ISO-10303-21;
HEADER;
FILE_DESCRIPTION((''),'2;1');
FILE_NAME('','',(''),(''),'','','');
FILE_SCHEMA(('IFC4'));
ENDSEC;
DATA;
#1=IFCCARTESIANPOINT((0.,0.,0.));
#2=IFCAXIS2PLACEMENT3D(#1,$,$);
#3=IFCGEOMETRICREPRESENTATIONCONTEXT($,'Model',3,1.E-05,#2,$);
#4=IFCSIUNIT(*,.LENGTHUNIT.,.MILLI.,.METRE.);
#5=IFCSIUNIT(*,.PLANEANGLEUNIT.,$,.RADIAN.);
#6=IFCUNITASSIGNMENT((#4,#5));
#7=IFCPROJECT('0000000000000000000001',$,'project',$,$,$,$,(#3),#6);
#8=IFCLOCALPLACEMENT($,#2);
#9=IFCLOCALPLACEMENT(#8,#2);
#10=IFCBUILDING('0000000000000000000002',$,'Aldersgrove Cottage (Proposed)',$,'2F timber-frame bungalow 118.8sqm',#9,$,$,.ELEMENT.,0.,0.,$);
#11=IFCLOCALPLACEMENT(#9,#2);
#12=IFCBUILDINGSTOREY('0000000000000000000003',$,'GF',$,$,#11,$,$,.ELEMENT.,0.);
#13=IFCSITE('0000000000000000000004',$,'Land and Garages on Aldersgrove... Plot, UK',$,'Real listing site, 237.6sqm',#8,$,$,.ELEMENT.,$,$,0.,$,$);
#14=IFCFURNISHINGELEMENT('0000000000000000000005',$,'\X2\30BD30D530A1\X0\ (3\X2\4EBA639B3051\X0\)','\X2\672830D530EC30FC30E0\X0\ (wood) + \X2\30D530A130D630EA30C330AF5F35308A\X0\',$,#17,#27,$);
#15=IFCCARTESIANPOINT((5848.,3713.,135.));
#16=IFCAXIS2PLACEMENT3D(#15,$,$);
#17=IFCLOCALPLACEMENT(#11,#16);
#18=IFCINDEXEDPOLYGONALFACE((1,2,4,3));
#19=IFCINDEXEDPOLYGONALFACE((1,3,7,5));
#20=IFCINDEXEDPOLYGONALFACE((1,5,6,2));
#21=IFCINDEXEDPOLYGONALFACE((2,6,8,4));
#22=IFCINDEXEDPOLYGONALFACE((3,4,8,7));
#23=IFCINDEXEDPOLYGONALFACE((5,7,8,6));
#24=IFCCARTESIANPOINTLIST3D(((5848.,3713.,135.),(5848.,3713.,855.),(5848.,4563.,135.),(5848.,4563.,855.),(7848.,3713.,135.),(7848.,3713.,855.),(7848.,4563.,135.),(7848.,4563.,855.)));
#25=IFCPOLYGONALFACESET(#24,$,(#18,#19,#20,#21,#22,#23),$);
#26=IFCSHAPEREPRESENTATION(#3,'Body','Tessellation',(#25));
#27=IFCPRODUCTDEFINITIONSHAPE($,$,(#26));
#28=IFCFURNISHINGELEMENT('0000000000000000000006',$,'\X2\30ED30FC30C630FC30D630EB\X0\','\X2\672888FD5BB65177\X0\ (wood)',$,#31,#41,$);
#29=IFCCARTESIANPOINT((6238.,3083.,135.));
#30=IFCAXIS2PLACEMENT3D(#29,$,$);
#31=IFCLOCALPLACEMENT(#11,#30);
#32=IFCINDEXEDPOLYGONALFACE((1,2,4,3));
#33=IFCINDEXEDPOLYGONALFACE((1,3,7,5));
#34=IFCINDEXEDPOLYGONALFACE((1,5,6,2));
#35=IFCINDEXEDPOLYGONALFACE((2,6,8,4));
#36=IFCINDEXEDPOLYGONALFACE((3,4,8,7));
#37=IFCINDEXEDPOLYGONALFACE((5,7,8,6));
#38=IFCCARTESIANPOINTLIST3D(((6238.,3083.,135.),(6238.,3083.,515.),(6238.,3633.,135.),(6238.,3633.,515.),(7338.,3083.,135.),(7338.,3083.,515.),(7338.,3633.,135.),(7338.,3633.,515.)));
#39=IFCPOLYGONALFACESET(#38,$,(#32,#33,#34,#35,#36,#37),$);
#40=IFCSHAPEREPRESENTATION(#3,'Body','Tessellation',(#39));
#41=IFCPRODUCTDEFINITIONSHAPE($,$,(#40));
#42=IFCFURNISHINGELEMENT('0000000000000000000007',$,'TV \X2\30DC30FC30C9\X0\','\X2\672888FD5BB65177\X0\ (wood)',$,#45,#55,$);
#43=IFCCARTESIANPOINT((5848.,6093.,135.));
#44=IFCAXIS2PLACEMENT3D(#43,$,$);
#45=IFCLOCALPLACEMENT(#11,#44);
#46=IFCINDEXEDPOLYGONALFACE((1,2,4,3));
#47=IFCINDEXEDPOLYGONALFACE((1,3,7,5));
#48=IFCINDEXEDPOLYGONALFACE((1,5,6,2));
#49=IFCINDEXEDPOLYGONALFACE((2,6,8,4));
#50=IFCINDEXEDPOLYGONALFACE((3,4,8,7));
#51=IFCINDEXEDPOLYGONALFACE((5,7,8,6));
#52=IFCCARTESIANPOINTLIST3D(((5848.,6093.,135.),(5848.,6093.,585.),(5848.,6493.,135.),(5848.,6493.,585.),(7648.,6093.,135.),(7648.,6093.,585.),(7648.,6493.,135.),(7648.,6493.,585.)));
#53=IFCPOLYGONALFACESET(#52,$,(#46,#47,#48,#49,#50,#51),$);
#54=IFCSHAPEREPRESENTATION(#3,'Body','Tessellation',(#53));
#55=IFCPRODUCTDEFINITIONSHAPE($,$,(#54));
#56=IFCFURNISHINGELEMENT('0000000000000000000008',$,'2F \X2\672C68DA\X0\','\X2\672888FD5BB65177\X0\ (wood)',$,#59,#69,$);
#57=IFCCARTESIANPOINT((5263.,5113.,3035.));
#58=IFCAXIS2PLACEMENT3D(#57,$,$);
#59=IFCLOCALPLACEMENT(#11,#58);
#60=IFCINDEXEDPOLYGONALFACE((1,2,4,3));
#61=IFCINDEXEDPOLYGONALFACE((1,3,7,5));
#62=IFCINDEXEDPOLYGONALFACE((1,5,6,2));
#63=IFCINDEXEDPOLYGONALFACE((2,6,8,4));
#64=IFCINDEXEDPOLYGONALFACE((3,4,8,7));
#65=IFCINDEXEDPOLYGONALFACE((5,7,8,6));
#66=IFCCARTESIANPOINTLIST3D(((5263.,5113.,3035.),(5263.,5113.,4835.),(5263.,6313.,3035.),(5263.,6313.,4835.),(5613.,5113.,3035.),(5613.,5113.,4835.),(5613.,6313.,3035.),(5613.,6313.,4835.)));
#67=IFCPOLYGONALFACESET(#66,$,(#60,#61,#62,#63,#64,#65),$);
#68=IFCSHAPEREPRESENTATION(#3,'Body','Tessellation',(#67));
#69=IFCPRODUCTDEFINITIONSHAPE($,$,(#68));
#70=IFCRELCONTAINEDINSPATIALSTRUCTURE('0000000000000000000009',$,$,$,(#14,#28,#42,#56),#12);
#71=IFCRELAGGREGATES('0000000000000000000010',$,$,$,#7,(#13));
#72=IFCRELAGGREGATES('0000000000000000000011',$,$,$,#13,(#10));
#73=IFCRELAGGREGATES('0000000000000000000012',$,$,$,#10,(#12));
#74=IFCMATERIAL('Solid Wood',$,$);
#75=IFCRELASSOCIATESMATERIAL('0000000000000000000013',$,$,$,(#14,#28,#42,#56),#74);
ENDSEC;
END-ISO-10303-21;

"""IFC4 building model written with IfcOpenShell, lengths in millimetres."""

from ifc_helpers import new_model, si_unit, frame, frame_2d, origin, place, context, project, spatial, rectangle, extrude, material, element, save


model = new_model("IFC4")

# Units and contexts
model_context = context("Model", 3, precision=1e-05, world=origin())
ifc_project = project(units=[si_unit("LENGTHUNIT", "METRE", prefix="MILLI"), si_unit("PLANEANGLEUNIT", "RADIAN")], contexts=[model_context])

# Site, building, storey
site_placement = place(None, origin())
site = spatial("IfcSite", under=ifc_project, at=site_placement, Name="Land and Garages on Aldersgrove... Plot, UK", ObjectType="Real listing site, 237.6sqm", CompositionType="ELEMENT", RefElevation=0.0)
building_placement = place(site_placement, origin())
building = spatial("IfcBuilding", under=site, at=building_placement, Name="Aldersgrove Cottage (Proposed)", ObjectType="2F timber-frame bungalow 118.8sqm", CompositionType="ELEMENT", ElevationOfRefHeight=0.0, ElevationOfTerrain=0.0)
storey_placement = place(building_placement, origin())
storey = spatial("IfcBuildingStorey", under=building, at=storey_placement, Name="GF", CompositionType="ELEMENT", Elevation=0.0)

# Shared definitions
ifc_material_1 = material(Name="Solid Wood")

# Furnishing elements
furnishing_1_placement = place(storey_placement, frame((5848.0, 3713.0, 135.0)))
element("IfcFurnishingElement", 1, at=furnishing_1_placement, inside=storey, material=ifc_material_1, Name="ソファ (3人掛け)", Description="木フレーム (wood) + ファブリック張り", context=model_context, shape_type="SweptSolid", body=[
    extrude(rectangle(XDim=2000.0, YDim=850.0, at=frame_2d((1000.0, 425.0))), frame((5848.0, 3713.0, 135.0)), (0.0, 0.0, 1.0), 720.0),
])
furnishing_2_placement = place(storey_placement, frame((6238.0, 3083.0, 135.0)))
element("IfcFurnishingElement", 2, at=furnishing_2_placement, inside=storey, material=ifc_material_1, Name="ローテーブル", Description="木製家具 (wood)", context=model_context, shape_type="SweptSolid", body=[
    extrude(rectangle(XDim=1100.0, YDim=550.0, at=frame_2d((550.0, 275.0))), frame((6238.0, 3083.0, 135.0)), (0.0, 0.0, 1.0), 380.0),
])
furnishing_3_placement = place(storey_placement, frame((5848.0, 6093.0, 135.0)))
element("IfcFurnishingElement", 3, at=furnishing_3_placement, inside=storey, material=ifc_material_1, Name="TV ボード", Description="木製家具 (wood)", context=model_context, shape_type="SweptSolid", body=[
    extrude(rectangle(XDim=1800.0, YDim=400.0, at=frame_2d((900.0, 200.0))), frame((5848.0, 6093.0, 135.0)), (0.0, 0.0, 1.0), 450.0),
])
furnishing_4_placement = place(storey_placement, frame((5263.0, 5113.0, 3035.0)))
element("IfcFurnishingElement", 4, at=furnishing_4_placement, inside=storey, material=ifc_material_1, Name="2F 本棚", Description="木製家具 (wood)", context=model_context, shape_type="SweptSolid", body=[
    extrude(rectangle(XDim=350.0, YDim=1200.0, at=frame_2d((175.0, 600.0))), frame((5263.0, 5113.0, 3035.0)), (0.0, 0.0, 1.0), 1800.0),
])

save(model, "model.ifc")
